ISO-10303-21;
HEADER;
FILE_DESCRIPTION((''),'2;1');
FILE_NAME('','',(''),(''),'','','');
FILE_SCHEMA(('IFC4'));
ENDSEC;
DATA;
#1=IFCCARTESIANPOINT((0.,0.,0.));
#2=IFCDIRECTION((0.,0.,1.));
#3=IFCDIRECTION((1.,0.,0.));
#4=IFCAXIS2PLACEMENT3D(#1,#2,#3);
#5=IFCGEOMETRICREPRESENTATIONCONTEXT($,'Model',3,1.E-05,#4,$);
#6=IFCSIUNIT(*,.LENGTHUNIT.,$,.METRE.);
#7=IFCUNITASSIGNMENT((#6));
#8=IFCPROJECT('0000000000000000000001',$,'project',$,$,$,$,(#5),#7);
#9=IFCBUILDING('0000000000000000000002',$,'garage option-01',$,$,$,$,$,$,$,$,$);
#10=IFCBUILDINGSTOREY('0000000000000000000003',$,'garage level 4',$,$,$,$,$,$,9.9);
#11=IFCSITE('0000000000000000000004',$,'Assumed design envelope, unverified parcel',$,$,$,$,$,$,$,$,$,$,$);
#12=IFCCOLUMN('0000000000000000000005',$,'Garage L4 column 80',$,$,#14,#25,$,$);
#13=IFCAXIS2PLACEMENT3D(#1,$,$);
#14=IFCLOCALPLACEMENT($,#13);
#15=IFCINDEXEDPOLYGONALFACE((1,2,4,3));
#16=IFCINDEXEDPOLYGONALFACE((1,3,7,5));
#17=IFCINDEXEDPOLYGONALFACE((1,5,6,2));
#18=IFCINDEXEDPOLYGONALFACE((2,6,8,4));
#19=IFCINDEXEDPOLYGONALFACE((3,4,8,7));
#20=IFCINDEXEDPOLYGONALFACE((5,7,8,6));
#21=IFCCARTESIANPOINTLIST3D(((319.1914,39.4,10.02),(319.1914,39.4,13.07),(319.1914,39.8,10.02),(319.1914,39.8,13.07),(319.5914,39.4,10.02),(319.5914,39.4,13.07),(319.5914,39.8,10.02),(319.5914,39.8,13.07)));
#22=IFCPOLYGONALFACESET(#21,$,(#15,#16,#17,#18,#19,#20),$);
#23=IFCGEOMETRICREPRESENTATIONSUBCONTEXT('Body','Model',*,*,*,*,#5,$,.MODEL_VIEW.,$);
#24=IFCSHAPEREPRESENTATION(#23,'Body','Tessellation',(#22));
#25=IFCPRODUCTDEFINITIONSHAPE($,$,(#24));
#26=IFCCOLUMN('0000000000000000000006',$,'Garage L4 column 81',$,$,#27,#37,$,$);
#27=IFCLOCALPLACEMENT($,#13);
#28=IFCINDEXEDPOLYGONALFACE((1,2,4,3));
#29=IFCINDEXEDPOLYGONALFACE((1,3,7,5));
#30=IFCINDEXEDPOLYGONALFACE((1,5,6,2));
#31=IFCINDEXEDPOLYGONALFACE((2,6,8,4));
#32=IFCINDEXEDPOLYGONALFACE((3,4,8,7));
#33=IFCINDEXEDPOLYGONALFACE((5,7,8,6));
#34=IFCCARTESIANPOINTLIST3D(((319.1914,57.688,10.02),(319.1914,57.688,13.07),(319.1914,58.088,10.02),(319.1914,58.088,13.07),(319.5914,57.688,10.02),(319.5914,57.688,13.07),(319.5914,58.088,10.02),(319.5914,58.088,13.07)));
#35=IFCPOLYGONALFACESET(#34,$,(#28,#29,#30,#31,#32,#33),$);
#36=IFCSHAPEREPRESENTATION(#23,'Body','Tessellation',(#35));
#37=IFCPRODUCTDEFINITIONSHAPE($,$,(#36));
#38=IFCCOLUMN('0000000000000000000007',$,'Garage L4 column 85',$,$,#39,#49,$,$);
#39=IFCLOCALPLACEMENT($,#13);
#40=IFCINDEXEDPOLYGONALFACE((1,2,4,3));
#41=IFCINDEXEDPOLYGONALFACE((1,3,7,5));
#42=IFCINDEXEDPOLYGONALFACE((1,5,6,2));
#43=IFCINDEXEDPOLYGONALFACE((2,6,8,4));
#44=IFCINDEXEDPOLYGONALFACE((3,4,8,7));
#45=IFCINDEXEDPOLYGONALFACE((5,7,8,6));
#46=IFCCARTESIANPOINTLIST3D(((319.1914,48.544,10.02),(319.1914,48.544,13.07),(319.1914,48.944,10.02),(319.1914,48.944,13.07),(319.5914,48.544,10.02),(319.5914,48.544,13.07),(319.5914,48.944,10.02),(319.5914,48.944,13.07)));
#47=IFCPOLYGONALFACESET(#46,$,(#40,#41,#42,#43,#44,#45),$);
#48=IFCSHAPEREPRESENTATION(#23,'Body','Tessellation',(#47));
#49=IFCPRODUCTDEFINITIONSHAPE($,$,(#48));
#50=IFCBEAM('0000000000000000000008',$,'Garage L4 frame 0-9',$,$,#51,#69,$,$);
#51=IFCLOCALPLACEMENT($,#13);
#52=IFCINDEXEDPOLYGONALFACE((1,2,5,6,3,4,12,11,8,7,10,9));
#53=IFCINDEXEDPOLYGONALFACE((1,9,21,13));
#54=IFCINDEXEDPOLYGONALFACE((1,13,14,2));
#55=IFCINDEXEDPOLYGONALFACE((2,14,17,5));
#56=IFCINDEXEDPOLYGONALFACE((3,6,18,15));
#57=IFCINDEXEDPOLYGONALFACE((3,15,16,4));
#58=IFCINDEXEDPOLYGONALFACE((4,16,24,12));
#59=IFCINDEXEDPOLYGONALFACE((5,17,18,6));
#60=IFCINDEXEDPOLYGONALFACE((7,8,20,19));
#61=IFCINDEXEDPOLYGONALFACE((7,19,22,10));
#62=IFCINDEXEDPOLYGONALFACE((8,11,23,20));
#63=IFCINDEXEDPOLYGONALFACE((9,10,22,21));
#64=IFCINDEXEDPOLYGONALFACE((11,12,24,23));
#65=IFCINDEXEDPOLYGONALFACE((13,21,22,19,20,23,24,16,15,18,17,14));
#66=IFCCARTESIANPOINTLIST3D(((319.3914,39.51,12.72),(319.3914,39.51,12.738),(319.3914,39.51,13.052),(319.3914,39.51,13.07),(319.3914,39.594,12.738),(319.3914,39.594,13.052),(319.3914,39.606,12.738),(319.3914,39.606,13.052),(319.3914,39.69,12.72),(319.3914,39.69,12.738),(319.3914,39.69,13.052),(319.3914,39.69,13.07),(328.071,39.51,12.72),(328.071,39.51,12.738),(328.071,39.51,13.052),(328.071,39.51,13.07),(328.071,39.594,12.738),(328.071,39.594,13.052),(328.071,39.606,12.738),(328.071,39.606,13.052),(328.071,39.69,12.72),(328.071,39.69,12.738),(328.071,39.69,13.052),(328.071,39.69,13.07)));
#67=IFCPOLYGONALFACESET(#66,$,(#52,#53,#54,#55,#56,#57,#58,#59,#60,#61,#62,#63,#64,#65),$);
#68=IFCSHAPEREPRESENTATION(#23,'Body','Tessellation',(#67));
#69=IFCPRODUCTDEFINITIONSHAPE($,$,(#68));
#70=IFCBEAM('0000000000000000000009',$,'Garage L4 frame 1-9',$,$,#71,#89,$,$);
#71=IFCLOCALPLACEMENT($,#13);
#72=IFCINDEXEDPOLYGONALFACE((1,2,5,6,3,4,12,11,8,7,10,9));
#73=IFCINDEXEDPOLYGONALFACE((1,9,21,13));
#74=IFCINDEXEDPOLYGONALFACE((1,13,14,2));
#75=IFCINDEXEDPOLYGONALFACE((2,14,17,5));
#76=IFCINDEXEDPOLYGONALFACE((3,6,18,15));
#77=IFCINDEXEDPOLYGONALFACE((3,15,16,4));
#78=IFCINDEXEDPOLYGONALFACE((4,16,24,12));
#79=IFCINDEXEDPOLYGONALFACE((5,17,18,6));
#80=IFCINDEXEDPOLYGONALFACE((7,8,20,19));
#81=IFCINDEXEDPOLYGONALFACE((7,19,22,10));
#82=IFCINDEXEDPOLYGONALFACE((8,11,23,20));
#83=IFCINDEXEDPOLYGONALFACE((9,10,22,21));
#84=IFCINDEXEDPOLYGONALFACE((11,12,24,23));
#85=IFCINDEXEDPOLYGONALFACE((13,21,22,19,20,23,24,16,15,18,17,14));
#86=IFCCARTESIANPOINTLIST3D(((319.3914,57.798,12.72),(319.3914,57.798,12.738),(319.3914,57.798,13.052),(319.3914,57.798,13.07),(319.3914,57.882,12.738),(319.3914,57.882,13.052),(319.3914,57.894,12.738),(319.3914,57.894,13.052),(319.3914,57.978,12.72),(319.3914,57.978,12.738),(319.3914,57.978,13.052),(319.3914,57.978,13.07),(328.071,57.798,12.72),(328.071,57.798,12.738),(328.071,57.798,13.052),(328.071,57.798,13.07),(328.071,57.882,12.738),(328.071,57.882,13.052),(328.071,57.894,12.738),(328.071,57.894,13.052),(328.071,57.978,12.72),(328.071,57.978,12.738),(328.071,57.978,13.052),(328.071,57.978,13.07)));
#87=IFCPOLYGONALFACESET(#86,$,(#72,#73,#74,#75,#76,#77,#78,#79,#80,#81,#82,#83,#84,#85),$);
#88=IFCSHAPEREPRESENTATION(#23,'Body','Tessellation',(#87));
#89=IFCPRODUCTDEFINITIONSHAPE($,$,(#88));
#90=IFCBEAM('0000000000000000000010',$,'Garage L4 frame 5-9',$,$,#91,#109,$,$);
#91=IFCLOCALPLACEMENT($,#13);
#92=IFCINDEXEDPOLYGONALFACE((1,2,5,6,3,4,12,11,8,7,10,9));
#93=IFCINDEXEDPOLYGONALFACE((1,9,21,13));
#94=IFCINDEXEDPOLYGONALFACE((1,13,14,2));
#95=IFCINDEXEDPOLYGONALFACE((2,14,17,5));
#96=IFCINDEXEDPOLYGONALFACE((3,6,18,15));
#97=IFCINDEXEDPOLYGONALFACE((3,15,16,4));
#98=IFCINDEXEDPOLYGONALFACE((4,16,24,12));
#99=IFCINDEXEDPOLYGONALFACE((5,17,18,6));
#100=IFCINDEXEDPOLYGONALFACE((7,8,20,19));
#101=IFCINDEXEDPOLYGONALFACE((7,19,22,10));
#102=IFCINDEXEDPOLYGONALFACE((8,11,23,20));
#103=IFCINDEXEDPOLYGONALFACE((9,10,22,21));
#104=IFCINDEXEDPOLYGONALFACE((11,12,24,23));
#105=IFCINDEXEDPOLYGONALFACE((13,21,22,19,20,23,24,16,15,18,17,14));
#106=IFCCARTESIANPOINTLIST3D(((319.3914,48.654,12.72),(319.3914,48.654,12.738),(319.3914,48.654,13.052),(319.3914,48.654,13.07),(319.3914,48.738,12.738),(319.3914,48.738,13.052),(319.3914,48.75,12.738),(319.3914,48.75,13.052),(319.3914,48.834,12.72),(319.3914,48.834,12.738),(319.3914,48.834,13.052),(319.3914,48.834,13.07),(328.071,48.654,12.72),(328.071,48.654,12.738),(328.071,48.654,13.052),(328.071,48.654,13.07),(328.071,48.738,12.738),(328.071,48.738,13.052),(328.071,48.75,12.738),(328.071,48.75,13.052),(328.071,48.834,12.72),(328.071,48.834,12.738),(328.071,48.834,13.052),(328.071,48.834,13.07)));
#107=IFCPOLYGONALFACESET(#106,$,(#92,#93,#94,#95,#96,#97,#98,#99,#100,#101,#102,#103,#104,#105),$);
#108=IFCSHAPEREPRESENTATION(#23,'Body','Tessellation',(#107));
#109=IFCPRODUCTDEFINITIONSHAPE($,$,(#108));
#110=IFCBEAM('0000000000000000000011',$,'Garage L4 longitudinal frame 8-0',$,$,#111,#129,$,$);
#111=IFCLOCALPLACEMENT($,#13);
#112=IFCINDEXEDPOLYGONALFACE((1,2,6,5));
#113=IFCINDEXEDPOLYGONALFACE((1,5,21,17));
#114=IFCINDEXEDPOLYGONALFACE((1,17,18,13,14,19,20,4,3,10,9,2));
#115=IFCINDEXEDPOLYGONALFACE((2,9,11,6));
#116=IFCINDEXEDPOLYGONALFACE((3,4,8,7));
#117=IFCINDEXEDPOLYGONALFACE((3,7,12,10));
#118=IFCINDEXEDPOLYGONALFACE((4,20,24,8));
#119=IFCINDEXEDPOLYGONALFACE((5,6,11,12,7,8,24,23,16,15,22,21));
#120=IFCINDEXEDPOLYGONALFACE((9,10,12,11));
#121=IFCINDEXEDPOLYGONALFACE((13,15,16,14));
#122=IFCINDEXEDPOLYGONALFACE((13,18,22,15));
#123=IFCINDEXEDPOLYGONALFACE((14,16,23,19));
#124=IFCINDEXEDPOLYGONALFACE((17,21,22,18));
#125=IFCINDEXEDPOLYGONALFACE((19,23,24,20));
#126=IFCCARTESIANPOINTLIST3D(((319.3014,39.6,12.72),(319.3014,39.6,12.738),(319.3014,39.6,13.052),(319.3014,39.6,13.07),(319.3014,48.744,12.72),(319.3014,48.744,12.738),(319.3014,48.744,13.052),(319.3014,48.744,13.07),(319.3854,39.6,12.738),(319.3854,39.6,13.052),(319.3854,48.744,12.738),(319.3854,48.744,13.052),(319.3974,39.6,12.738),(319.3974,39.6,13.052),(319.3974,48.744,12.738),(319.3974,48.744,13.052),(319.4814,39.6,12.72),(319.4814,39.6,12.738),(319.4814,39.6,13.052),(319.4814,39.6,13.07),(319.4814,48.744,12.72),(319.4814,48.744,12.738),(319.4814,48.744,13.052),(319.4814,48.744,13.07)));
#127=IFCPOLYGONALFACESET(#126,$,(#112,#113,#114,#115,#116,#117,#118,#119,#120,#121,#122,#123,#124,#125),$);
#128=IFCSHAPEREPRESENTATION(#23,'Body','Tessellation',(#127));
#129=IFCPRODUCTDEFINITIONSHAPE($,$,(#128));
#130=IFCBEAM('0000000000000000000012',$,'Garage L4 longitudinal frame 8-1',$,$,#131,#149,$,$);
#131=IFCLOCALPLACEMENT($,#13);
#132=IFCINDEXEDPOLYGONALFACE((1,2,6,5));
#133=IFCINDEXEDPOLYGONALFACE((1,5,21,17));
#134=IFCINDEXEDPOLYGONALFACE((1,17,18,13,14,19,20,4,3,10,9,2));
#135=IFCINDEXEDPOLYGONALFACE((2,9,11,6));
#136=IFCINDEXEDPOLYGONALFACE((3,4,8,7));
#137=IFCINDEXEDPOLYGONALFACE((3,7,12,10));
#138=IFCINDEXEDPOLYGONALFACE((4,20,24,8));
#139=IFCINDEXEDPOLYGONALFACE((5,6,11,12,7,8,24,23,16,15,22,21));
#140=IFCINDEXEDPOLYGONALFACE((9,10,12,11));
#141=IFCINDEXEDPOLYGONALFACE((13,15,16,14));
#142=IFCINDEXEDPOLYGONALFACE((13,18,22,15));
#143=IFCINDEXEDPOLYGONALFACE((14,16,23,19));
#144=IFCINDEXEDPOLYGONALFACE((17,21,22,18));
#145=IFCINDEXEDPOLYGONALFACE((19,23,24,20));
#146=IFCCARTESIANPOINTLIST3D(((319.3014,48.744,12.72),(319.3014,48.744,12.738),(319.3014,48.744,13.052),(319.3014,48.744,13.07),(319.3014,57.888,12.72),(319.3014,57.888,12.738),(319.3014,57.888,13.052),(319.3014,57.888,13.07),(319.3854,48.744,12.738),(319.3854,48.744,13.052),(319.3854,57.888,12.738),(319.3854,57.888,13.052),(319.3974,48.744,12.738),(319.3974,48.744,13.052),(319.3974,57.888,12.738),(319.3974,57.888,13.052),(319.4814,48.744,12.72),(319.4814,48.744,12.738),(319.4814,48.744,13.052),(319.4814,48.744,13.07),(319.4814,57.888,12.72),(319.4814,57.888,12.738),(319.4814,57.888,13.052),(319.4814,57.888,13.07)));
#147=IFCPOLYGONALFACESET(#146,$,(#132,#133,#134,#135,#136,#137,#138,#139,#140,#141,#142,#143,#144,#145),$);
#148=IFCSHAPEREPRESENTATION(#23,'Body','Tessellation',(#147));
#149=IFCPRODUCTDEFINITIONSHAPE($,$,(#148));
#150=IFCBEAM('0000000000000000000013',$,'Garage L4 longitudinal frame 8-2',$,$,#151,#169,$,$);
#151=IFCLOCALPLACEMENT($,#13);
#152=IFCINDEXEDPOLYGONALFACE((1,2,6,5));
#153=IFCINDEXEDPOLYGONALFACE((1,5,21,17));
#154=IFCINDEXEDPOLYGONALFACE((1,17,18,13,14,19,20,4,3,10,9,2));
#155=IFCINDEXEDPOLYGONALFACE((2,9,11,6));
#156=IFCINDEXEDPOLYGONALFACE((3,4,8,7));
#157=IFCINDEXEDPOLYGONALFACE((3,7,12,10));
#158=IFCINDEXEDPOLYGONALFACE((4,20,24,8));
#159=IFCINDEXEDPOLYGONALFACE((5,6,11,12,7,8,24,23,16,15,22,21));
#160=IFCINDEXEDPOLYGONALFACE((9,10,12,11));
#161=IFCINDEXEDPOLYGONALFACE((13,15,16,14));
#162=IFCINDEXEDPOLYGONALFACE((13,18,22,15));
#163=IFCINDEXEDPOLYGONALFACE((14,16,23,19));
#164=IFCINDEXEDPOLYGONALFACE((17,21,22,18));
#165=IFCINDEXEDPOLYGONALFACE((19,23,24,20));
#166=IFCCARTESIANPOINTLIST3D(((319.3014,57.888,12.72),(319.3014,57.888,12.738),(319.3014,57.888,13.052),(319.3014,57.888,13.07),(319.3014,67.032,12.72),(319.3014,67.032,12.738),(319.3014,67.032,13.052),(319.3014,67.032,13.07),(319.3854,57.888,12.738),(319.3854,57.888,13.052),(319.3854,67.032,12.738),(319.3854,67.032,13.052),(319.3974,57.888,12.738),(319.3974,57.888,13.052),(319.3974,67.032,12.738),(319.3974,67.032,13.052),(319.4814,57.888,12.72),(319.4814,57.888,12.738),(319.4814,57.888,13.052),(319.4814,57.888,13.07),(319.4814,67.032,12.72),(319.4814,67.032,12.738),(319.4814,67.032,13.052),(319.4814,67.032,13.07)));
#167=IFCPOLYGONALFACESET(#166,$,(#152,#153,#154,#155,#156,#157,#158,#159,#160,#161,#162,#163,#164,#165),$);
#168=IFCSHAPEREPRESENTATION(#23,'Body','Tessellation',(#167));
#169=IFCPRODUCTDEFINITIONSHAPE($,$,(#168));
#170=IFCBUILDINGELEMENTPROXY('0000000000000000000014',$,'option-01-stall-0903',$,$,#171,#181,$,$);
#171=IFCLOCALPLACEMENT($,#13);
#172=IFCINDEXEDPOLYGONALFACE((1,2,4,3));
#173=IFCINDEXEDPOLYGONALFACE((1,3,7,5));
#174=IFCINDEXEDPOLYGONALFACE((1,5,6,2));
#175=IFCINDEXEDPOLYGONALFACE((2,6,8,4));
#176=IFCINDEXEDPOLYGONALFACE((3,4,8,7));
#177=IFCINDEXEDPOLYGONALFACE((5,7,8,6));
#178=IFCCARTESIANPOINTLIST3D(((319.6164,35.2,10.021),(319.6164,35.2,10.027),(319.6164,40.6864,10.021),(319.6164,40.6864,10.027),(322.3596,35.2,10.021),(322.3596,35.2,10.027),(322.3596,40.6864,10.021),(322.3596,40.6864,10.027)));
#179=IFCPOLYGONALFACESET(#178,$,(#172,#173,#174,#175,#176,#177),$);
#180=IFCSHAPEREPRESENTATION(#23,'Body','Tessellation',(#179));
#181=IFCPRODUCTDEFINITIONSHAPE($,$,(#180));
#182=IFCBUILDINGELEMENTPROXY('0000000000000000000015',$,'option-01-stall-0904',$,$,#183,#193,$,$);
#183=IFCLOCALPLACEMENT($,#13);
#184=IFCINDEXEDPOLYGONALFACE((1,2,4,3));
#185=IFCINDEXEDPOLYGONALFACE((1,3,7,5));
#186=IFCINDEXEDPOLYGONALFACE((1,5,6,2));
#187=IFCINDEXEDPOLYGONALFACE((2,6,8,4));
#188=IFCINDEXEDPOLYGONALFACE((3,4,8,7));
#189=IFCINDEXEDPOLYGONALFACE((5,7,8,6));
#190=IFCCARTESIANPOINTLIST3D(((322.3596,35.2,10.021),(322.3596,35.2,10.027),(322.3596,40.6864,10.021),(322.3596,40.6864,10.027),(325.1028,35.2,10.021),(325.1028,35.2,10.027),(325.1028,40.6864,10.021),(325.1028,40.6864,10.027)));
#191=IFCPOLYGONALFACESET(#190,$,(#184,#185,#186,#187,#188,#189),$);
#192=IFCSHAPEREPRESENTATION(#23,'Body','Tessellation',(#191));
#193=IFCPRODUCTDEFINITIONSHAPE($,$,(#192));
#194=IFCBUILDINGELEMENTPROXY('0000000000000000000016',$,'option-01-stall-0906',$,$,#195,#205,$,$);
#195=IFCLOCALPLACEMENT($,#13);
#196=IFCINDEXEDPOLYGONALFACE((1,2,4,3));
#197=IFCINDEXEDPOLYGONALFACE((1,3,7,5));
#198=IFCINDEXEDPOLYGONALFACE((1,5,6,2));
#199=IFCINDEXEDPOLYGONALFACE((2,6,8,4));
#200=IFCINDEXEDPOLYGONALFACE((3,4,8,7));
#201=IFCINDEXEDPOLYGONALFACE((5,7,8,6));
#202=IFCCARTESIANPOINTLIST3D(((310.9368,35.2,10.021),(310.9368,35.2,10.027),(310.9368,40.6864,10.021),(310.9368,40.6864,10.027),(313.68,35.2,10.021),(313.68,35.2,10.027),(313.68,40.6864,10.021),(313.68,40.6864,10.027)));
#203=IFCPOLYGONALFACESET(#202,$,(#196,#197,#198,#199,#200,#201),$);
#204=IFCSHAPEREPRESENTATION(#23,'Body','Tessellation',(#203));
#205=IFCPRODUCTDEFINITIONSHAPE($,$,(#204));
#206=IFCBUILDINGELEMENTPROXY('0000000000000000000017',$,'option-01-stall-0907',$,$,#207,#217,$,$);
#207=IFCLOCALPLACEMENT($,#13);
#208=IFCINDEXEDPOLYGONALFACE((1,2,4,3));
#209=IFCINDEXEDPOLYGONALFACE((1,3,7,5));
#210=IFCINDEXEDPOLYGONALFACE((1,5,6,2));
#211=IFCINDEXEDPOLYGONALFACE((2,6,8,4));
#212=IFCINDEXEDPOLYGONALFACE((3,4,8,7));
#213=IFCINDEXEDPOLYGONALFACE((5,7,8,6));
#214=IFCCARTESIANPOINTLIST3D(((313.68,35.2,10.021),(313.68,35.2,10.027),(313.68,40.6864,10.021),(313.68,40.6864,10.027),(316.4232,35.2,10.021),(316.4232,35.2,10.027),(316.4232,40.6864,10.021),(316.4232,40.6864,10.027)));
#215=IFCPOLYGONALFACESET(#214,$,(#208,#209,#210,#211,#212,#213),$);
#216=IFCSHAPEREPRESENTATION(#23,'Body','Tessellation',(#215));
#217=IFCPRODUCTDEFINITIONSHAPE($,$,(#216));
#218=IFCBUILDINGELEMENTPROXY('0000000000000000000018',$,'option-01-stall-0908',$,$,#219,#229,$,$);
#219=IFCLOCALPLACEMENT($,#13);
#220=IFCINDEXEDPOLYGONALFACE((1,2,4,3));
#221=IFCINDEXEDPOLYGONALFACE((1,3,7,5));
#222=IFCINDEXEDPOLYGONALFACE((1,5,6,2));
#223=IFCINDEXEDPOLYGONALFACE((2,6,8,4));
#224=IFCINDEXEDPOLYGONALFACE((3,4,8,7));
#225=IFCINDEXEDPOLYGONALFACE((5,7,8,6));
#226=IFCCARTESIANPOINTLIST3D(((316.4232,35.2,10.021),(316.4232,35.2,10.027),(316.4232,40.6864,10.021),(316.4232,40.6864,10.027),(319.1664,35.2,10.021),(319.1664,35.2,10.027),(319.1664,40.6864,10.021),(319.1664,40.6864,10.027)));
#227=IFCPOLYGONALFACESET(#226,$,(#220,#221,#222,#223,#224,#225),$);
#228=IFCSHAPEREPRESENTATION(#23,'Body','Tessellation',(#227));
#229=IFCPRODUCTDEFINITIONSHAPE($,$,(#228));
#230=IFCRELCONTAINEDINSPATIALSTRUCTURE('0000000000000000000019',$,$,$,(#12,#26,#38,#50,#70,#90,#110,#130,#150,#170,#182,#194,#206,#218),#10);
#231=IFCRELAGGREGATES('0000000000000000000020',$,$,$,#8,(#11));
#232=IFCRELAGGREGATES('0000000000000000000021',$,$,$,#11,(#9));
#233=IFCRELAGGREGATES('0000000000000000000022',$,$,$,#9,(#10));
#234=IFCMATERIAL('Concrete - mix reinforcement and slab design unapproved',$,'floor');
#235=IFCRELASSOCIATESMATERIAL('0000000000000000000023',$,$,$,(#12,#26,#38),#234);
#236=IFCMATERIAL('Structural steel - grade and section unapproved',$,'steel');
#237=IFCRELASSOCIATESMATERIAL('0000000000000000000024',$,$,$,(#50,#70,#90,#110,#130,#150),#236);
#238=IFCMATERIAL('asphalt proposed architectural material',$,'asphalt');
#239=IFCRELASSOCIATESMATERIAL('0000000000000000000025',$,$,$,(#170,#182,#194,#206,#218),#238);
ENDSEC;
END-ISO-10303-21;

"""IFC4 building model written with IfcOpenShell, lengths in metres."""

from ifc_helpers import new_model, si_unit, frame, origin_with_axes, place, context, subcontext, project, spatial, rectangle, i_section, extrude, material, element, save


model = new_model("IFC4")

# Units and contexts
model_context = context("Model", 3, precision=1e-05, world=origin_with_axes())
body_context = subcontext(model_context, "Body", "Model", "MODEL_VIEW")
ifc_project = project(units=[si_unit("LENGTHUNIT", "METRE")], contexts=[model_context])

# Site, building, storey
site = spatial("IfcSite", under=ifc_project, Name="Assumed design envelope, unverified parcel")
building = spatial("IfcBuilding", under=site, Name="garage option-01")
storey = spatial("IfcBuildingStorey", under=building, Name="garage level 4", Elevation=9.9)

# Columns
ifc_material_1 = material(Name="Concrete - mix reinforcement and slab design unapproved", Category="floor")
for number, where, z_axis, x_axis, name in (
    (1, (319.3914, 39.6, 10.02), (0.0, 0.0, 1.0), (1.0, 0.0, 0.0), "Garage L4 column 80"),
    (2, (319.3914, 57.888, 10.02), (0.0, 0.0, 1.0), (1.0, 0.0, 0.0), "Garage L4 column 81"),
    (3, (319.3914, 48.744, 10.02), (0.0, 0.0, 1.0), (1.0, 0.0, 0.0), "Garage L4 column 85"),
):
    element("IfcColumn", number, at=place(None, frame(where, z_axis=z_axis, x_axis=x_axis)), inside=storey, material=ifc_material_1, Name=name, context=body_context, shape_type="SweptSolid", body=[
        extrude(rectangle(XDim=0.4, YDim=0.4), origin_with_axes(), (0.0, 0.0, 1.0), 3.05),
    ])

# Beams
ifc_material_2 = material(Name="Structural steel - grade and section unapproved", Category="steel")
for number, where, z_axis, x_axis, name in (
    (4, (319.3914, 39.6, 12.895), (1.0, 0.0, 0.0), (0.0, 1.0, 0.0), "Garage L4 frame 0-9"),
    (5, (319.3914, 57.888, 12.895), (1.0, 0.0, 0.0), (0.0, 1.0, 0.0), "Garage L4 frame 1-9"),
    (6, (319.3914, 48.744, 12.895), (1.0, 0.0, 0.0), (0.0, 1.0, 0.0), "Garage L4 frame 5-9"),
):
    element("IfcBeam", number, at=place(None, frame(where, z_axis=z_axis, x_axis=x_axis)), inside=storey, material=ifc_material_2, Name=name, context=body_context, shape_type="SweptSolid", body=[
        extrude(i_section(OverallWidth=0.18, OverallDepth=0.35, WebThickness=0.012, FlangeThickness=0.018, FilletRadius=0.0), origin_with_axes(), (0.0, 0.0, 1.0), 8.6796),
    ])
for number, where, z_axis, x_axis, name in (
    (7, (319.3914, 39.6, 12.895), (0.0, 1.0, 0.0), (-1.0, 0.0, 0.0), "Garage L4 longitudinal frame 8-0"),
    (8, (319.3914, 48.744, 12.895), (0.0, 1.0, 0.0), (-1.0, 0.0, 0.0), "Garage L4 longitudinal frame 8-1"),
):
    element("IfcBeam", number, at=place(None, frame(where, z_axis=z_axis, x_axis=x_axis)), inside=storey, material=ifc_material_2, Name=name, context=body_context, shape_type="SweptSolid", body=[
        extrude(i_section(OverallWidth=0.18, OverallDepth=0.35, WebThickness=0.012, FlangeThickness=0.018, FilletRadius=0.0), origin_with_axes(), (0.0, 0.0, 1.0), 9.144),
    ])
beam_placement = place(None, frame((319.3914, 57.888, 12.895), z_axis=(0.0, 1.0, 0.0), x_axis=(-1.0, 0.0, 0.0)))
element("IfcBeam", 9, at=beam_placement, inside=storey, material=ifc_material_2, Name="Garage L4 longitudinal frame 8-2", context=body_context, shape_type="SweptSolid", body=[
    extrude(i_section(OverallWidth=0.18, OverallDepth=0.35, WebThickness=0.012, FlangeThickness=0.018, FilletRadius=0.0), origin_with_axes(), (0.0, 0.0, 1.0), 9.144),
])

# Building element proxies
ifc_material_3 = material(Name="asphalt proposed architectural material", Category="asphalt")
for number, where, z_axis, x_axis, name in (
    (10, (320.988, 37.9432, 10.021), (0.0, 0.0, 1.0), (1.0, 0.0, 0.0), "option-01-stall-0903"),
    (11, (323.7312, 37.9432, 10.021), (0.0, 0.0, 1.0), (1.0, 0.0, 0.0), "option-01-stall-0904"),
    (12, (312.3084, 37.9432, 10.021), (0.0, 0.0, 1.0), (1.0, 0.0, 0.0), "option-01-stall-0906"),
    (13, (315.0516, 37.9432, 10.021), (0.0, 0.0, 1.0), (1.0, 0.0, 0.0), "option-01-stall-0907"),
    (14, (317.7948, 37.9432, 10.021), (0.0, 0.0, 1.0), (1.0, 0.0, 0.0), "option-01-stall-0908"),
):
    element("IfcBuildingElementProxy", number, at=place(None, frame(where, z_axis=z_axis, x_axis=x_axis)), inside=storey, material=ifc_material_3, Name=name, context=body_context, shape_type="SweptSolid", body=[
        extrude(rectangle(XDim=2.7432, YDim=5.4864), origin_with_axes(), (0.0, 0.0, 1.0), 0.006),
    ])

save(model, "model.ifc")
